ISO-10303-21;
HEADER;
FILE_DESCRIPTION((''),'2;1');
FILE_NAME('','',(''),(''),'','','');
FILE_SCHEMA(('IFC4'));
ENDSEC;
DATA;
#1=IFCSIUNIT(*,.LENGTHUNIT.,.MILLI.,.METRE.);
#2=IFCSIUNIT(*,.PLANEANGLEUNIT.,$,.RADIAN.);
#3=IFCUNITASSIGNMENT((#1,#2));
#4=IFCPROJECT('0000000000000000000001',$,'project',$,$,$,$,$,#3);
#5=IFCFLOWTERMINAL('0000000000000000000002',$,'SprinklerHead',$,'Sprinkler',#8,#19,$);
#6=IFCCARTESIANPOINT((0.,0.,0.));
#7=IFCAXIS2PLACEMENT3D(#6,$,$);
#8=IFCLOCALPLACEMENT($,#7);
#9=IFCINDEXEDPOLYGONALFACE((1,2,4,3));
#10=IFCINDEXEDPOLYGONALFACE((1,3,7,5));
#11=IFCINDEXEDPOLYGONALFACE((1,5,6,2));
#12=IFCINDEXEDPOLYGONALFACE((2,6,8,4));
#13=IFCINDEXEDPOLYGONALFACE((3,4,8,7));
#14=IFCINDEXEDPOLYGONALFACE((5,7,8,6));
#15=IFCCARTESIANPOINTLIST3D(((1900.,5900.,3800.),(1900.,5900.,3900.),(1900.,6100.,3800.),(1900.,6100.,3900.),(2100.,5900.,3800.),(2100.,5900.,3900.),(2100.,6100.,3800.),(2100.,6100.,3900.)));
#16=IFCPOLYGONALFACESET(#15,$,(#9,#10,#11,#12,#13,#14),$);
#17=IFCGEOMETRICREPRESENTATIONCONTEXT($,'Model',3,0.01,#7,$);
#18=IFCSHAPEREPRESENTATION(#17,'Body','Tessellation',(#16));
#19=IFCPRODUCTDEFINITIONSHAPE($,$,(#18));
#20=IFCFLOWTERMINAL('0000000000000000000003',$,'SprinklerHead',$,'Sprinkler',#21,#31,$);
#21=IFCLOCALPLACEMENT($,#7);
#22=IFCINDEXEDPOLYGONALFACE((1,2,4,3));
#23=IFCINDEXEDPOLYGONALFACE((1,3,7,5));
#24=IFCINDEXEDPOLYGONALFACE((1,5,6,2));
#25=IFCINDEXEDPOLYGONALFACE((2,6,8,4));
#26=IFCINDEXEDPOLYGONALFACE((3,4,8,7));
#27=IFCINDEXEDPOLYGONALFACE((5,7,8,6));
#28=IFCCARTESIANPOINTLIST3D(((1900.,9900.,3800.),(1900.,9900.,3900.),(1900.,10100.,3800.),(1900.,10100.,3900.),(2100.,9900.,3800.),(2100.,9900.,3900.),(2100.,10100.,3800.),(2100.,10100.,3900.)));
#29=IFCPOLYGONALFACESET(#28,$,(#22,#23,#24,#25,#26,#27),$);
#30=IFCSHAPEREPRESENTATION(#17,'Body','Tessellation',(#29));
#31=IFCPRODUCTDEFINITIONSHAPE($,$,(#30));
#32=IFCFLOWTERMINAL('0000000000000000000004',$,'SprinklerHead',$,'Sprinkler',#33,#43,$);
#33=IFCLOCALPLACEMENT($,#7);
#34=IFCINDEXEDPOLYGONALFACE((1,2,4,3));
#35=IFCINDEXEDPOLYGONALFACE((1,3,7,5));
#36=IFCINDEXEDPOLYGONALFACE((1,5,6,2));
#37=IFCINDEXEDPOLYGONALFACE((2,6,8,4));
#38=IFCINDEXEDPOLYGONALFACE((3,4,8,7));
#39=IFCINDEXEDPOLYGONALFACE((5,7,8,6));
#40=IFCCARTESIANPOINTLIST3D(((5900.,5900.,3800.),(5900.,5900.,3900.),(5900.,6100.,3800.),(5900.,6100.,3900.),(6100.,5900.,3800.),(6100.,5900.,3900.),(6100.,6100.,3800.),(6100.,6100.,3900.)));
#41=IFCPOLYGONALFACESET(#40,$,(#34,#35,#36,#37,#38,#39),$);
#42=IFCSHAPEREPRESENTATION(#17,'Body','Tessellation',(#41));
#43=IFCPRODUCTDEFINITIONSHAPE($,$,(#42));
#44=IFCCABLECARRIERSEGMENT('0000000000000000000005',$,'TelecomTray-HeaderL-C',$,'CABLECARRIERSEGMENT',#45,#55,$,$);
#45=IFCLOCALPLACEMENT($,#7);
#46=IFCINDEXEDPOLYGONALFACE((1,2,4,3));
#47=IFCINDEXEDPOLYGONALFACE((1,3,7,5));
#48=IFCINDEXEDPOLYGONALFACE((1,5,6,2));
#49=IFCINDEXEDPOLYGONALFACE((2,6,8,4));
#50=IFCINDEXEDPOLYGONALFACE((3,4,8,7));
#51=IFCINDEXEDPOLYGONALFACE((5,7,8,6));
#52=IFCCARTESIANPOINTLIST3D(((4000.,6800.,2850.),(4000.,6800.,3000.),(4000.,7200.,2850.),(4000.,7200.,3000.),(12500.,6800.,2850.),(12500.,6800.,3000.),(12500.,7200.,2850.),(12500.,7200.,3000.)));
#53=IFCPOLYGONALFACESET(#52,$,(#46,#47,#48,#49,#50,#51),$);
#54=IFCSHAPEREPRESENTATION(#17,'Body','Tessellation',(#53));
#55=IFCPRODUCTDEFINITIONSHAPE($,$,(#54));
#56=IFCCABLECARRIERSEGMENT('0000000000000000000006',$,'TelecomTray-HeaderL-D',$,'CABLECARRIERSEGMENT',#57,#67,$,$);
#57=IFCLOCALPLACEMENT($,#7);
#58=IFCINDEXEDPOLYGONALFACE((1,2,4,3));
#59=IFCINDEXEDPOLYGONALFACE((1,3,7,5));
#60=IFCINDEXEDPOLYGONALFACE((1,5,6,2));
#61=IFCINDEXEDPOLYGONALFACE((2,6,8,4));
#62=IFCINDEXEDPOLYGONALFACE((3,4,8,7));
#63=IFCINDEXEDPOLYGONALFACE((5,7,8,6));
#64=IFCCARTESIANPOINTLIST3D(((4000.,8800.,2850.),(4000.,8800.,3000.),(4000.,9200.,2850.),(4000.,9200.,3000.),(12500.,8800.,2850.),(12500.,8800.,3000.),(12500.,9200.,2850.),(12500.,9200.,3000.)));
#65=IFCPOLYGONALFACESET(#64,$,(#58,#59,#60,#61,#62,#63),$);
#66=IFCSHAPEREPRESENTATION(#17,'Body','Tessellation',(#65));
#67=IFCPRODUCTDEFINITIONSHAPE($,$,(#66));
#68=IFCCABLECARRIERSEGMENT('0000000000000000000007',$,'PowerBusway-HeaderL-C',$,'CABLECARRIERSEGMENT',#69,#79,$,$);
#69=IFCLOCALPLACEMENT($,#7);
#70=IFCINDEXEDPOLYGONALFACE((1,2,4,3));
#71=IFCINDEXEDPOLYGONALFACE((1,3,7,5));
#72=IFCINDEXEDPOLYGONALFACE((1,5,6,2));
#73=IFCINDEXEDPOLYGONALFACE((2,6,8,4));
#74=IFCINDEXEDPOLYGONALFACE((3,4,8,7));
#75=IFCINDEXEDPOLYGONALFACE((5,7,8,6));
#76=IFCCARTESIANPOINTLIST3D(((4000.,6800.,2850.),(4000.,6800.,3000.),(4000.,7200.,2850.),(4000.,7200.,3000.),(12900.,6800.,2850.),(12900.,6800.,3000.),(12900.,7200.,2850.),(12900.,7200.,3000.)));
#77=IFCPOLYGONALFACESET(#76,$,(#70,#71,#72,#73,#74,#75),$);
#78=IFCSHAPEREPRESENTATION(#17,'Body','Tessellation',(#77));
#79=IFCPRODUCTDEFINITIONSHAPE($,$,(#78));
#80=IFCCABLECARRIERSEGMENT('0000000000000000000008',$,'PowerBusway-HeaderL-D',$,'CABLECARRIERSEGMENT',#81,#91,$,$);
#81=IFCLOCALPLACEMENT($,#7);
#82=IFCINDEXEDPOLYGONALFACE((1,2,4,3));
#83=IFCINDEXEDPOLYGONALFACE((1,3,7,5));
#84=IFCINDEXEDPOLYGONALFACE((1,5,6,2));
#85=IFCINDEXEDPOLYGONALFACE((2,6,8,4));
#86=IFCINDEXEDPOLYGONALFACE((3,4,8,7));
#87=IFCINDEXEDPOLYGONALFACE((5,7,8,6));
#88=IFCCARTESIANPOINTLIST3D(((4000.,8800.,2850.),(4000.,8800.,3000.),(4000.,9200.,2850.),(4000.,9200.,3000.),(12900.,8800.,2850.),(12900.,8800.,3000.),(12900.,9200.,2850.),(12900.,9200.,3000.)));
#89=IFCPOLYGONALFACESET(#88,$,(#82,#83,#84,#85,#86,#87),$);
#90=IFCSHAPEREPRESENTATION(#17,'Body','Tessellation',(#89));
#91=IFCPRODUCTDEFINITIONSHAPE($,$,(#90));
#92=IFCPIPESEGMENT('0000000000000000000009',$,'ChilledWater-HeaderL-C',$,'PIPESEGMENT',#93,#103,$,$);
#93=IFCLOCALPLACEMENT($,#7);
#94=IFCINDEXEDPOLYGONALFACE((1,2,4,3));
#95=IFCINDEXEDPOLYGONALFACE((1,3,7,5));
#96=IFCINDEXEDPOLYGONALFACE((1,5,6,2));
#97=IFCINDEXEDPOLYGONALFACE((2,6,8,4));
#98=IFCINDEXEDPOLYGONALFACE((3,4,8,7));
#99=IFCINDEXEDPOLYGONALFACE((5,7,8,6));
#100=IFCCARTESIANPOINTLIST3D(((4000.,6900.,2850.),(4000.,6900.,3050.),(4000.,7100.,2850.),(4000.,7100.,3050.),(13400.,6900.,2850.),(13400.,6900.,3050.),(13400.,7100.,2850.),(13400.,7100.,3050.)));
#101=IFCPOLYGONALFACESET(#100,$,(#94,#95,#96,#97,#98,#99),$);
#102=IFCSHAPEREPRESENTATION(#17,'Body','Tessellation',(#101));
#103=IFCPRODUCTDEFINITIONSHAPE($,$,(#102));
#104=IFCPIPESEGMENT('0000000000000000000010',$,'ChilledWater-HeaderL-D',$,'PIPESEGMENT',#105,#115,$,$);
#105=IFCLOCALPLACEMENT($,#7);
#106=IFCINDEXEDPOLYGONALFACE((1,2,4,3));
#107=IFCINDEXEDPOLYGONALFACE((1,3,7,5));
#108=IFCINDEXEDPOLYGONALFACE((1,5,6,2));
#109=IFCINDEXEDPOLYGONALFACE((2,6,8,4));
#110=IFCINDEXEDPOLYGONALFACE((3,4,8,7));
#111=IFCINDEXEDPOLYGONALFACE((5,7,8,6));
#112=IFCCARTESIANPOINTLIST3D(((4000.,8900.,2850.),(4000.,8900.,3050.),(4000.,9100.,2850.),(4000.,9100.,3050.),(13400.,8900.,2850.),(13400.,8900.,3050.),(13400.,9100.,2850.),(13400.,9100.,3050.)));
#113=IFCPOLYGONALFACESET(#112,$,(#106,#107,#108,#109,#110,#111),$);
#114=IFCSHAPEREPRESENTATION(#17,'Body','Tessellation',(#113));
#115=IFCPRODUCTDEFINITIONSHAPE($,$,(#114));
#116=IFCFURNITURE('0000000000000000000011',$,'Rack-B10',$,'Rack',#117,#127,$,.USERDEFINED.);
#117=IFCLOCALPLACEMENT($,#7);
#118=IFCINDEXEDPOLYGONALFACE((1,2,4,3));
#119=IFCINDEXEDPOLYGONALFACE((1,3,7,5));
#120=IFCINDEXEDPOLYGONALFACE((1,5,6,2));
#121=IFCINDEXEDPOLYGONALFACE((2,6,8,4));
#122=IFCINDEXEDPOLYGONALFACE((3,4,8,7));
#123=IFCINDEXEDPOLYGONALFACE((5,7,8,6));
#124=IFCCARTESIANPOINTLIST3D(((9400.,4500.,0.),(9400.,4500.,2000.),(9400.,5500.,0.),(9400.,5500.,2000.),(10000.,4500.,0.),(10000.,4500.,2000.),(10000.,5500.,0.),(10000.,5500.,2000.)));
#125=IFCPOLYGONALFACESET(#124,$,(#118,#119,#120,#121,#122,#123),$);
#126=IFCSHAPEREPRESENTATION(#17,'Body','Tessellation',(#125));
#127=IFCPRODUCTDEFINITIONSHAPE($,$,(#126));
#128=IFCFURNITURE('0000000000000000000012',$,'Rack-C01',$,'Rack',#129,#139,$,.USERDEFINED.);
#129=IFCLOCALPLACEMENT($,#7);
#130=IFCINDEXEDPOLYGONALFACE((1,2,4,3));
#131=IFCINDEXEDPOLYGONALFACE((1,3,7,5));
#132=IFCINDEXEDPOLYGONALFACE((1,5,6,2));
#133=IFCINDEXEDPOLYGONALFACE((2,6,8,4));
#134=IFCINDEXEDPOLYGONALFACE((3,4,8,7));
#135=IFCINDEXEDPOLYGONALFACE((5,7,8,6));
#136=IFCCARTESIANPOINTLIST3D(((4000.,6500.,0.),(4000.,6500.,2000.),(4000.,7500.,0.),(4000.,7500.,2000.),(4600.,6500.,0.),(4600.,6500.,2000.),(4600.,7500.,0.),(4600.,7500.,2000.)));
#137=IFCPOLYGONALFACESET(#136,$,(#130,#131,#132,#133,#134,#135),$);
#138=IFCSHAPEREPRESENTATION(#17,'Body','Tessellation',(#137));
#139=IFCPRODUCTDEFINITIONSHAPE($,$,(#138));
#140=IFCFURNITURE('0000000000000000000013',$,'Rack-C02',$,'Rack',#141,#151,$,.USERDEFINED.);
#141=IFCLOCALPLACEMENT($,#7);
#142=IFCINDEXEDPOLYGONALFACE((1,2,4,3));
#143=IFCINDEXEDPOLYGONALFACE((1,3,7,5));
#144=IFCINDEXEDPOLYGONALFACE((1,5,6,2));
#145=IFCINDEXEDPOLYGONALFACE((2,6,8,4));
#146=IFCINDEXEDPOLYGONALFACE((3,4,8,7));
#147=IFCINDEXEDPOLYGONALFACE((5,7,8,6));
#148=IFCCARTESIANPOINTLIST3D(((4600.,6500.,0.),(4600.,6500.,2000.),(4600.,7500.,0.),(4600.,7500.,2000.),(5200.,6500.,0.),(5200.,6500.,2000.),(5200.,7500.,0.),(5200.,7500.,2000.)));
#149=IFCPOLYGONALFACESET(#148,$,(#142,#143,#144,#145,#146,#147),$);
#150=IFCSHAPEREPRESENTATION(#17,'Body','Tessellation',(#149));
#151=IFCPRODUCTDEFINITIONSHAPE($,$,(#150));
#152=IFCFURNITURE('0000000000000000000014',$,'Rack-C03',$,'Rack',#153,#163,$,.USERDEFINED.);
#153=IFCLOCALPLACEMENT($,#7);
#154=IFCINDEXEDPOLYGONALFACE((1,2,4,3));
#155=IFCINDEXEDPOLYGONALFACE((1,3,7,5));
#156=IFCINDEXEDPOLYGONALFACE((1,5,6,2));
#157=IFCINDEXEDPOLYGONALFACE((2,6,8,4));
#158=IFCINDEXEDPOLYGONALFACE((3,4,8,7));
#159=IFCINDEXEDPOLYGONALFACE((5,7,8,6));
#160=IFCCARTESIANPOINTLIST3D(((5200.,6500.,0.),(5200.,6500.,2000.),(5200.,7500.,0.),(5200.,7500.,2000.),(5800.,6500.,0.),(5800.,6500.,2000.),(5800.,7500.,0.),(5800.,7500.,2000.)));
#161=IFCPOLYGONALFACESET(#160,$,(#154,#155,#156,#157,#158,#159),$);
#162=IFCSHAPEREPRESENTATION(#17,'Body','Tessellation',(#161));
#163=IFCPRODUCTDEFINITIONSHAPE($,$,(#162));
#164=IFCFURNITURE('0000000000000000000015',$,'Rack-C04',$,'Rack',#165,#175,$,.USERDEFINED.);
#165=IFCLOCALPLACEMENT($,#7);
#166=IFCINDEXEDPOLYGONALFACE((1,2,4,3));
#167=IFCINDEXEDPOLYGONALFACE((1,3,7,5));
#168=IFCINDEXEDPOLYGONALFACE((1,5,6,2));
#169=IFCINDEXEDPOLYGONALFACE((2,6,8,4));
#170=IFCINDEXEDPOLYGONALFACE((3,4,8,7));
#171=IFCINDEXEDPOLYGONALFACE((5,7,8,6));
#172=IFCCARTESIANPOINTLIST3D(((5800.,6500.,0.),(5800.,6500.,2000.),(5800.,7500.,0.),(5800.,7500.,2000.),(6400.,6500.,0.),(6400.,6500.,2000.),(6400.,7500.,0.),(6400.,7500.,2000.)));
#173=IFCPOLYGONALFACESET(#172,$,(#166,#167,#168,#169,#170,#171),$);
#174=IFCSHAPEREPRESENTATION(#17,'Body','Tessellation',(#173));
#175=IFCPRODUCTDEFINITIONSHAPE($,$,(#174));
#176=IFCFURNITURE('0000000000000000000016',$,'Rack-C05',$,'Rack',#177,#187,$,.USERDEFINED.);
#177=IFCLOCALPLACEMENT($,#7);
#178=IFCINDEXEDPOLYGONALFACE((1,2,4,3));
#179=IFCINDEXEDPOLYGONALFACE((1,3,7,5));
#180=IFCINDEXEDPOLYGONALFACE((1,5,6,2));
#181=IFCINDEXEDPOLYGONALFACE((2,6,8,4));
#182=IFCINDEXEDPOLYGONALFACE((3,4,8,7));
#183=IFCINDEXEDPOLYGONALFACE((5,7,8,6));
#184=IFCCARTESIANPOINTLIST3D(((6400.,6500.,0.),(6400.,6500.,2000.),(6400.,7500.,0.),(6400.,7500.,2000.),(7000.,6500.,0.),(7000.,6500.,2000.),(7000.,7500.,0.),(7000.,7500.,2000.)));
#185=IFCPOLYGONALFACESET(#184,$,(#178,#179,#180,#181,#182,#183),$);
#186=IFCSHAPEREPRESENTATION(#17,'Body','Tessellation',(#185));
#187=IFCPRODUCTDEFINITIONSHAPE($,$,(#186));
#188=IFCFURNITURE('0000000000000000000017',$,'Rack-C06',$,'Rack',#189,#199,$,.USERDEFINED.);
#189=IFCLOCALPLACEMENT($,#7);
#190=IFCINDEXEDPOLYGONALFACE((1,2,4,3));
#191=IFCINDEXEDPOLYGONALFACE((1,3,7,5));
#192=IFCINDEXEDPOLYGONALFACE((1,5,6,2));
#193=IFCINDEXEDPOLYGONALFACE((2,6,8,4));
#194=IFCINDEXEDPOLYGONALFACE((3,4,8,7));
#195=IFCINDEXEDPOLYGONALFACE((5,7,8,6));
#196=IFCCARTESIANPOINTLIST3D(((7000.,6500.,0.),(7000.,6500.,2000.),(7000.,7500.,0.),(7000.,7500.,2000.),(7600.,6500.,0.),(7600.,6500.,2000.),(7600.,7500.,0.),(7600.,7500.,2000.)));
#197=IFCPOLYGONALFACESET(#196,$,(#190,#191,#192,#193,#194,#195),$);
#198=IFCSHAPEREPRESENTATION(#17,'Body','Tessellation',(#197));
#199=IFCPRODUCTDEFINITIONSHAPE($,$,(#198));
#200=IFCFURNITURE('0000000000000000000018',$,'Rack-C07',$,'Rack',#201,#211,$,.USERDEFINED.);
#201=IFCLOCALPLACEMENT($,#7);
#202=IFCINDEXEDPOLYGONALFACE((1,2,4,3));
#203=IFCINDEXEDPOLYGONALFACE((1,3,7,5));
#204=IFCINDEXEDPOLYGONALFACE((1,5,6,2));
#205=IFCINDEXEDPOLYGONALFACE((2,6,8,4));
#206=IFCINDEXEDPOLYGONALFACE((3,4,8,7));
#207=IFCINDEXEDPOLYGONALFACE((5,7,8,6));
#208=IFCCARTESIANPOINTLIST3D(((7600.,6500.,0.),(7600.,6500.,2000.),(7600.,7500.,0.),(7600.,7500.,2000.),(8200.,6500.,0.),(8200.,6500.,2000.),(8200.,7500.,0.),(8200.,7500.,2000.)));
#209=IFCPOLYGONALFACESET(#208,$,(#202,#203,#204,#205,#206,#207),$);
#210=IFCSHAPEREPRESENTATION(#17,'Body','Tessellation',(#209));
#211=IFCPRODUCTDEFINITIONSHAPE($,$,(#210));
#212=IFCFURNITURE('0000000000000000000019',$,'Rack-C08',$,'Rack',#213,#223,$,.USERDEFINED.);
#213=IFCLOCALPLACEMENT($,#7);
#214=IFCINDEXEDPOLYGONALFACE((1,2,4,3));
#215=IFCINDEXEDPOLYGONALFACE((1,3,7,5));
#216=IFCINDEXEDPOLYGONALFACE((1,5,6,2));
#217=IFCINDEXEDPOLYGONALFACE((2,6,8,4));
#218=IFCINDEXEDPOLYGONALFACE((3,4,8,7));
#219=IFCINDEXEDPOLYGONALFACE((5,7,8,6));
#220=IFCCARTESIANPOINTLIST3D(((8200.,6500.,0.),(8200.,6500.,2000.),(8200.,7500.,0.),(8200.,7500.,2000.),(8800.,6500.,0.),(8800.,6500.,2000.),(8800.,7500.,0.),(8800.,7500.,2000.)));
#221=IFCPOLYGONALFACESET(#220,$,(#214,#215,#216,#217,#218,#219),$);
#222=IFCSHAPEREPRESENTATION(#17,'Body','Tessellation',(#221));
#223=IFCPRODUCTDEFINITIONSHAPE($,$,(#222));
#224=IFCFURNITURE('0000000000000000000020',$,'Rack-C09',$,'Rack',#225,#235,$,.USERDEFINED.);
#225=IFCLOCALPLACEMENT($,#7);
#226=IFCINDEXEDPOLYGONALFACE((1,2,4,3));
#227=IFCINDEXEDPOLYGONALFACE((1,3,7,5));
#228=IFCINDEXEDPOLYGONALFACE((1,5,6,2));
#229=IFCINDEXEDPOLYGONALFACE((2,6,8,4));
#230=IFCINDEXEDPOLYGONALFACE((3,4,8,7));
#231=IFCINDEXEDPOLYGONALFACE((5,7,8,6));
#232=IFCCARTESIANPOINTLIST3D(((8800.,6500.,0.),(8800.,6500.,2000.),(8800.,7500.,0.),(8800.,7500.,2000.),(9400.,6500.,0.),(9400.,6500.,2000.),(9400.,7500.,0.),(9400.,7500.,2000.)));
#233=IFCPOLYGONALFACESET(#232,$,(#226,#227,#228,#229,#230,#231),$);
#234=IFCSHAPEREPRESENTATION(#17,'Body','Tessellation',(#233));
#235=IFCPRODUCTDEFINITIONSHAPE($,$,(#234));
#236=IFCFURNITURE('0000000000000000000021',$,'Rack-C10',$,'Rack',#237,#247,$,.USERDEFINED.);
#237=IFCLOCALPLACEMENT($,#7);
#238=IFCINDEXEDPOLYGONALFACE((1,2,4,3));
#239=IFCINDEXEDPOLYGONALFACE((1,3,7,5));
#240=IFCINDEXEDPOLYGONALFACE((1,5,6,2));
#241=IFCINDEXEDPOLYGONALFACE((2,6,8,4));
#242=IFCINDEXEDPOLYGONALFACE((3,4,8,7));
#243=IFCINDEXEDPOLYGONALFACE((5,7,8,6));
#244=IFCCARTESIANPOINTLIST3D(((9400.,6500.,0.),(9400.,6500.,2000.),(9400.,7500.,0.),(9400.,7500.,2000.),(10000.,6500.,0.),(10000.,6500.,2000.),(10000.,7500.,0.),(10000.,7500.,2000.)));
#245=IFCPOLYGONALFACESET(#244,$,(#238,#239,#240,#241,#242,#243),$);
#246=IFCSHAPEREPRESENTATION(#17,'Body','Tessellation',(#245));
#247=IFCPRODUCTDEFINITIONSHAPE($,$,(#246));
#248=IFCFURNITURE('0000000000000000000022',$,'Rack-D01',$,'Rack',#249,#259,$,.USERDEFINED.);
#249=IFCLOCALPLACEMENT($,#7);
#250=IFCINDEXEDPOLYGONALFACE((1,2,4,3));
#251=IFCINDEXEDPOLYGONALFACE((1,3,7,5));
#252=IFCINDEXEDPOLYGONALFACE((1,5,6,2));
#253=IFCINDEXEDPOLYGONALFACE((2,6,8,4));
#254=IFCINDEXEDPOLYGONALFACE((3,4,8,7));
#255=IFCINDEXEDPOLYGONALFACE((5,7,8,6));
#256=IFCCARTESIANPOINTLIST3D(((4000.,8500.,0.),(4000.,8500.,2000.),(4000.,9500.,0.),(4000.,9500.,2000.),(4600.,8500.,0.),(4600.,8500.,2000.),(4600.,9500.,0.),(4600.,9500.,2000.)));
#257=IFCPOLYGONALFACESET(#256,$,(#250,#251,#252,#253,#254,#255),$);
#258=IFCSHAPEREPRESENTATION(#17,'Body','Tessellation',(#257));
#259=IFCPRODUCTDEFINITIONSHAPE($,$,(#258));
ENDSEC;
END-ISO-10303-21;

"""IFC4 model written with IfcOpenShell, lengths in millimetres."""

from ifc_helpers import new_model, si_unit, frame, origin, place, context, project, polyline, outline, extrude, element, save


model = new_model("IFC4")

# Units and contexts
model_context = context("Model", 3, precision=0.01, world=origin())
ifc_project = project(units=[si_unit("LENGTHUNIT", "METRE", prefix="MILLI"), si_unit("PLANEANGLEUNIT", "RADIAN")])

# Flow terminals
for number, where, name in (
    (1, (2000.0, 6000.0, 3800.0), "SprinklerHead"),
    (2, (2000.0, 10000.0, 3800.0), "SprinklerHead"),
    (3, (6000.0, 6000.0, 3800.0), "SprinklerHead"),
):
    element("IfcFlowTerminal", number, at=place(None, frame(where)), Name=name, ObjectType="Sprinkler", context=model_context, shape_type="SweptSolid", body=[
        extrude(outline(polyline([(-100.0, -100.0), (100.0, -100.0), (100.0, 100.0), (-100.0, 100.0), (-100.0, -100.0)])), origin(), (0.0, 0.0, 1.0), 100.0),
    ])

# Cable carrier segments
for number, where, name in (
    (4, (8250.0, 7000.0, 2850.0), "TelecomTray-HeaderL-C"),
    (5, (8250.0, 9000.0, 2850.0), "TelecomTray-HeaderL-D"),
):
    element("IfcCableCarrierSegment", number, at=place(None, frame(where)), Name=name, ObjectType="CABLECARRIERSEGMENT", context=model_context, shape_type="SweptSolid", body=[
        extrude(outline(polyline([(-4250.0, -200.0), (4250.0, -200.0), (4250.0, 200.0), (-4250.0, 200.0), (-4250.0, -200.0)])), origin(), (0.0, 0.0, 1.0), 150.0),
    ])
for number, where, name in (
    (6, (8450.0, 7000.0, 2850.0), "PowerBusway-HeaderL-C"),
    (7, (8450.0, 9000.0, 2850.0), "PowerBusway-HeaderL-D"),
):
    element("IfcCableCarrierSegment", number, at=place(None, frame(where)), Name=name, ObjectType="CABLECARRIERSEGMENT", context=model_context, shape_type="SweptSolid", body=[
        extrude(outline(polyline([(-4450.0, -200.0), (4450.0, -200.0), (4450.0, 200.0), (-4450.0, 200.0), (-4450.0, -200.0)])), origin(), (0.0, 0.0, 1.0), 150.0),
    ])

# Pipe segments
for number, where, name in (
    (8, (8700.0, 7000.0, 2850.0), "ChilledWater-HeaderL-C"),
    (9, (8700.0, 9000.0, 2850.0), "ChilledWater-HeaderL-D"),
):
    element("IfcPipeSegment", number, at=place(None, frame(where)), Name=name, ObjectType="PIPESEGMENT", context=model_context, shape_type="SweptSolid", body=[
        extrude(outline(polyline([(-4700.0, -100.0), (4700.0, -100.0), (4700.0, 100.0), (-4700.0, 100.0), (-4700.0, -100.0)])), origin(), (0.0, 0.0, 1.0), 200.0),
    ])

# Furniture
for number, where, name in (
    (10, (9700.0, 5000.0, 0.0), "Rack-B10"),
    (11, (4300.0, 7000.0, 0.0), "Rack-C01"),
    (12, (4900.0, 7000.0, 0.0), "Rack-C02"),
    (13, (5500.0, 7000.0, 0.0), "Rack-C03"),
    (14, (6100.0, 7000.0, 0.0), "Rack-C04"),
    (15, (6700.0, 7000.0, 0.0), "Rack-C05"),
    (16, (7300.0, 7000.0, 0.0), "Rack-C06"),
    (17, (7900.0, 7000.0, 0.0), "Rack-C07"),
    (18, (8500.0, 7000.0, 0.0), "Rack-C08"),
    (19, (9100.0, 7000.0, 0.0), "Rack-C09"),
    (20, (9700.0, 7000.0, 0.0), "Rack-C10"),
    (21, (4300.0, 9000.0, 0.0), "Rack-D01"),
):
    element("IfcFurniture", number, at=place(None, frame(where)), Name=name, ObjectType="Rack", PredefinedType="USERDEFINED", context=model_context, shape_type="SweptSolid", body=[
        extrude(outline(polyline([(-300.0, -500.0), (300.0, -500.0), (300.0, 500.0), (-300.0, 500.0), (-300.0, -500.0)])), origin(), (0.0, 0.0, 1.0), 2000.0),
    ])

save(model, "model.ifc")
